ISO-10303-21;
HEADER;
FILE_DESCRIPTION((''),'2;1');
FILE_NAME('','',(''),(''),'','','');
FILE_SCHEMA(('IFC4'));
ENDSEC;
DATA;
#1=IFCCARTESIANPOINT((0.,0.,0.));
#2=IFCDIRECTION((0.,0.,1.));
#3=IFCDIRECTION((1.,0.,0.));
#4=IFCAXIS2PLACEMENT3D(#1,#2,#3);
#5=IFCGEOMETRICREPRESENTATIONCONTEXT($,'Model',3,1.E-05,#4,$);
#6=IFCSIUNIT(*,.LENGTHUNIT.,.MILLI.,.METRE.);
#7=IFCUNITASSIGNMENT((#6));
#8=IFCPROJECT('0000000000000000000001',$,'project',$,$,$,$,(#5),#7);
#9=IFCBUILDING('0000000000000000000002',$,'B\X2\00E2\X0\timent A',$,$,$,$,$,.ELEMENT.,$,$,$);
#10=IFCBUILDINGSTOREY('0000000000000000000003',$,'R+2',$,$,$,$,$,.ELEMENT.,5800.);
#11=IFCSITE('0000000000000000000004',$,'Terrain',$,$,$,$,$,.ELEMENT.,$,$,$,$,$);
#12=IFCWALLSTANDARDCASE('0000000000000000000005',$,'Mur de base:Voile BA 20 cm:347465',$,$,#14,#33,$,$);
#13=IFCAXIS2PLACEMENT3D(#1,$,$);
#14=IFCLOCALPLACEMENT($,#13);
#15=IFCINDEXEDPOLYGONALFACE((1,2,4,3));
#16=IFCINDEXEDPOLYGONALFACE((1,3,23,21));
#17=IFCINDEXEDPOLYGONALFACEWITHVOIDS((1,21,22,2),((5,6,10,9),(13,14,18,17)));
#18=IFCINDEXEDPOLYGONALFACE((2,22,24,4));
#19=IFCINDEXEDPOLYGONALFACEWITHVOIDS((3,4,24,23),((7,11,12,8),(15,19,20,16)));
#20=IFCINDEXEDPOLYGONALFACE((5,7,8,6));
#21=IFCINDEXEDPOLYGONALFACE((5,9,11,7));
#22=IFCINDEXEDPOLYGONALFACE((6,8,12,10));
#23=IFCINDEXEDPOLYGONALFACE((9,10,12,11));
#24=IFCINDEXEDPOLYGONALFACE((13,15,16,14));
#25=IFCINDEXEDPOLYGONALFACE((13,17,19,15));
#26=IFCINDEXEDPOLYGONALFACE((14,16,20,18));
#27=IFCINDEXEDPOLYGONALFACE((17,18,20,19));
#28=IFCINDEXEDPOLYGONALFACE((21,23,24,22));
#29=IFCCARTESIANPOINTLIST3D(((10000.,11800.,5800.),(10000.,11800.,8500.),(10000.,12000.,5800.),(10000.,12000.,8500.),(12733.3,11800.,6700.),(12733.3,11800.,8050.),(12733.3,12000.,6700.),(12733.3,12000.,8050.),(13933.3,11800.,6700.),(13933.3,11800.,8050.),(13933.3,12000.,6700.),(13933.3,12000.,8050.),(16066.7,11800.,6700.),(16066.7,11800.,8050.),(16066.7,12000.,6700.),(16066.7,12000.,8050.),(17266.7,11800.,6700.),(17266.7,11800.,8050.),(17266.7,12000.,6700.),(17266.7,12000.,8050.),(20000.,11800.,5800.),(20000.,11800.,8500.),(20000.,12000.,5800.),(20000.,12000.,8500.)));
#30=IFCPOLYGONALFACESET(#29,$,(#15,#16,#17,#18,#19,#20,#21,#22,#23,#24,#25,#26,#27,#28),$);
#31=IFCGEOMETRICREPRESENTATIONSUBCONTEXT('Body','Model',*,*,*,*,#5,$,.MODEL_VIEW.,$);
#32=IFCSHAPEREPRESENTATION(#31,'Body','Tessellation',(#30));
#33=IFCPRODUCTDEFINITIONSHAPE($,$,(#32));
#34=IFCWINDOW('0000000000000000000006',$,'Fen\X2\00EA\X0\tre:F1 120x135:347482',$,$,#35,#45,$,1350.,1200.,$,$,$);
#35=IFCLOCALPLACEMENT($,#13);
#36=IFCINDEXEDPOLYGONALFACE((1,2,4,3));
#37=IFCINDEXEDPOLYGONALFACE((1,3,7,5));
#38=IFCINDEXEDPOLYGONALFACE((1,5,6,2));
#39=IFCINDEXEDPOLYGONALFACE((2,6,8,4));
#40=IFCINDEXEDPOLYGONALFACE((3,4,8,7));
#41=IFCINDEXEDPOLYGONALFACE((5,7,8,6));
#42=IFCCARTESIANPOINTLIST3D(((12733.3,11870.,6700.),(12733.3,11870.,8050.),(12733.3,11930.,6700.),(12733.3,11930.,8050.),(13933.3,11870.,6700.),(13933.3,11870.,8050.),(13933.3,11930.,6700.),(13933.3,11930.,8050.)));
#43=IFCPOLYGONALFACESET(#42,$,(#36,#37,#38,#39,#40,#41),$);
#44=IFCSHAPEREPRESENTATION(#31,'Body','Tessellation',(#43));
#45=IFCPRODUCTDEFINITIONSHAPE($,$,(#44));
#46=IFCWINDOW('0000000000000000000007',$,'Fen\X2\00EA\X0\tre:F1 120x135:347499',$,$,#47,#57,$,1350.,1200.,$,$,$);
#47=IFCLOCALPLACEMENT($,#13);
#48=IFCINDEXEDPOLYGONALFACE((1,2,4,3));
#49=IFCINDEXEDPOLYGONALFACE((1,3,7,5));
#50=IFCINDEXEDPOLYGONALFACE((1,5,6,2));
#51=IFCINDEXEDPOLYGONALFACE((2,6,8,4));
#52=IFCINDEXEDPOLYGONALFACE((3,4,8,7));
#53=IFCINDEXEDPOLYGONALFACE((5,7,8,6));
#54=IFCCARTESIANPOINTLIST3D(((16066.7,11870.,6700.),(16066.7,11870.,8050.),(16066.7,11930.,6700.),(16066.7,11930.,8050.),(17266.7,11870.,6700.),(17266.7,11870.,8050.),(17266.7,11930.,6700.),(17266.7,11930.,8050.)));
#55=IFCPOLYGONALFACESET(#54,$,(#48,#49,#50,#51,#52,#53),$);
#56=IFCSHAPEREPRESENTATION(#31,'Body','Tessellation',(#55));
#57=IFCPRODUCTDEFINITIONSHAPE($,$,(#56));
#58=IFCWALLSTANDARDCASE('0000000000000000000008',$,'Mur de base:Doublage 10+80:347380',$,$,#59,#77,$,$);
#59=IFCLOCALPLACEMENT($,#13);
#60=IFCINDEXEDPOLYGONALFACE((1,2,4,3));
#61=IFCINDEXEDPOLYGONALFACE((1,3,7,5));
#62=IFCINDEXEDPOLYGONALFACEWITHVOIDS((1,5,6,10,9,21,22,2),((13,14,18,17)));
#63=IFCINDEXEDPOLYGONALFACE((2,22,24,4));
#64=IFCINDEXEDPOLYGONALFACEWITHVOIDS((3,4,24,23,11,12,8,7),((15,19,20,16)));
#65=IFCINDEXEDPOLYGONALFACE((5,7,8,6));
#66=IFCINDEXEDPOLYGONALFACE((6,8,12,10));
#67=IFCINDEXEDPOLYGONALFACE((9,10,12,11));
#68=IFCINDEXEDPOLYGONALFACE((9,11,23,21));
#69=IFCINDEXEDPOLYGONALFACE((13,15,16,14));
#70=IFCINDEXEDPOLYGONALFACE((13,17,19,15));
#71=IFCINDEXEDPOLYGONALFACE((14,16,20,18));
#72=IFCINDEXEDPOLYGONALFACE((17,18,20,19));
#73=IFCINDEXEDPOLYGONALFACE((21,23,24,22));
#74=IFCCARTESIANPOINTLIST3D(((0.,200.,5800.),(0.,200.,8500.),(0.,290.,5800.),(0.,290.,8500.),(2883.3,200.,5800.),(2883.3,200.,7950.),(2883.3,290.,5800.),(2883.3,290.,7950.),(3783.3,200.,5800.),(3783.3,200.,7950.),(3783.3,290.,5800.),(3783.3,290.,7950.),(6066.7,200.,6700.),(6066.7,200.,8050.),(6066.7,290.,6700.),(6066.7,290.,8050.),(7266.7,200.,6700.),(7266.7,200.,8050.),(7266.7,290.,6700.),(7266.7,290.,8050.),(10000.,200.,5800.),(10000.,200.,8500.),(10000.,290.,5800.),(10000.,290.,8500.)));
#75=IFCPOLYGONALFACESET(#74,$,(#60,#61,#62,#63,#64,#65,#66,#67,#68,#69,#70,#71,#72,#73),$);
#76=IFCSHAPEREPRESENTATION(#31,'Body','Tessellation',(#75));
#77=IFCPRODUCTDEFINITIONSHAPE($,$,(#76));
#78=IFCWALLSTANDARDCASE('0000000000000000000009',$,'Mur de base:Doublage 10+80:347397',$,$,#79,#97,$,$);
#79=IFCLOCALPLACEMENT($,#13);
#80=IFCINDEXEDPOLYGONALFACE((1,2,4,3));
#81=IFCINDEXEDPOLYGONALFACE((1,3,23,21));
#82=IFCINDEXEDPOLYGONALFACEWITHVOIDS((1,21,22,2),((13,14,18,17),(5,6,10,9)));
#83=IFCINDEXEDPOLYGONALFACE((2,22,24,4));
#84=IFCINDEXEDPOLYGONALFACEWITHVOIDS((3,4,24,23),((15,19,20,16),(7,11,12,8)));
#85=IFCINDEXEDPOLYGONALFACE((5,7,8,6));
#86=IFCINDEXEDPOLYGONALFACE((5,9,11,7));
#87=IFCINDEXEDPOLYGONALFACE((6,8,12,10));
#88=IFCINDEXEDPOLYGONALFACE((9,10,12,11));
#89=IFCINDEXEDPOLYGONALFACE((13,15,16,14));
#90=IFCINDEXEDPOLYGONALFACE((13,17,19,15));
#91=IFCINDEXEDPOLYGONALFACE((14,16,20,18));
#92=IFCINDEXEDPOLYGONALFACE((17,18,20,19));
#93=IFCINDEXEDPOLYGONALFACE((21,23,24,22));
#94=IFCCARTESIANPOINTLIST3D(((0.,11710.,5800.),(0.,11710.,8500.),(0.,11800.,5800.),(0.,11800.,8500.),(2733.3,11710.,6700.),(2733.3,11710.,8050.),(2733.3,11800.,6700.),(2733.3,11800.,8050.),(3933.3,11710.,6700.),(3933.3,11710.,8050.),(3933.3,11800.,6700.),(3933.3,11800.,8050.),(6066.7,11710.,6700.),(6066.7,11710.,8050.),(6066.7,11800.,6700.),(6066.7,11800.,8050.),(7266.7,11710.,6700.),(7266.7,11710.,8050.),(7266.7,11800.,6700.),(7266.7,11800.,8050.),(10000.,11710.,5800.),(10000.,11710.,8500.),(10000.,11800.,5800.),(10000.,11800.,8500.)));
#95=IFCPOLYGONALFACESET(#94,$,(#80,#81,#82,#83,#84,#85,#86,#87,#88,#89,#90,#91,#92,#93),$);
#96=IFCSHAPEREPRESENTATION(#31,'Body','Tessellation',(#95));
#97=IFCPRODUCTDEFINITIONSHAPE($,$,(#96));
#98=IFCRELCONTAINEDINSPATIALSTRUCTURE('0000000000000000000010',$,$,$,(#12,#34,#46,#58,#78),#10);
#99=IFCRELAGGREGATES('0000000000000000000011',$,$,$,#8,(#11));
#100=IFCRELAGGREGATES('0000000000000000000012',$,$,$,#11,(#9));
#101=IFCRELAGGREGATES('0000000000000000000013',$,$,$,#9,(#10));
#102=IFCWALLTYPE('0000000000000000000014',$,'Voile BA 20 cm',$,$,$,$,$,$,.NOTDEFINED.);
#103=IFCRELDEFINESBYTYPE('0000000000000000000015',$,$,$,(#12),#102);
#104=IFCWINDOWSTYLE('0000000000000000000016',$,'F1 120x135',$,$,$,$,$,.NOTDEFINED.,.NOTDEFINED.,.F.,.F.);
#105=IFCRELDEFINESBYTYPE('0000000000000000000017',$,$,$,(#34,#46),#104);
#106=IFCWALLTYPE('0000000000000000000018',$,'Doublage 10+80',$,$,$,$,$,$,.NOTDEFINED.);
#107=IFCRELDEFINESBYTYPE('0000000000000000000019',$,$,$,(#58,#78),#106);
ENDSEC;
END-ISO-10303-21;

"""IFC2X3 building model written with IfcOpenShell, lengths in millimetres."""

from ifc_helpers import new_model, si_unit, frame, frame_2d, origin_with_axes, place, context, subcontext, project, spatial, rectangle, extrude, type_object, element, fill, save


model = new_model("IFC2X3")

# Units and contexts
model_context = context("Model", 3, precision=1e-05, world=origin_with_axes())
body_context = subcontext(model_context, "Body", "Model", "MODEL_VIEW")
ifc_project = project(units=[si_unit("LENGTHUNIT", "METRE", prefix="MILLI")], contexts=[model_context])

# Site, building, storey
site = spatial("IfcSite", under=ifc_project, Name="Terrain", CompositionType="ELEMENT")
building = spatial("IfcBuilding", under=site, Name="Bâtiment A", CompositionType="ELEMENT")
storey = spatial("IfcBuildingStorey", under=building, Name="R+2", CompositionType="ELEMENT", Elevation=5800.0)

# Shared definitions
wall_type_1 = type_object("IfcWallType", Name="Voile BA 20 cm", PredefinedType="NOTDEFINED")
window_style = type_object("IfcWindowStyle", Name="F1 120x135", ConstructionType="NOTDEFINED", OperationType="NOTDEFINED", ParameterTakesPrecedence=False, Sizeable=False)

# Wall, openings, windows
wall_1_placement = place(None, origin_with_axes())
wall_1 = element("IfcWallStandardCase", 1, at=wall_1_placement, inside=storey, type_object=wall_type_1, Name="Mur de base:Voile BA 20 cm:347465", context=body_context, shape_type="SweptSolid", body=[
    extrude(rectangle(XDim=10000.0, YDim=200.0, at=frame_2d((15000.0, 11900.0))), frame((0.0, 0.0, 5800.0), z_axis=(0.0, 0.0, 1.0), x_axis=(1.0, 0.0, 0.0)), (0.0, 0.0, 1.0), 2700.0),
])
opening_1_placement = place(None, origin_with_axes())
opening_1 = element("IfcOpeningElement", 2, at=opening_1_placement, cuts=wall_1, context=body_context, shape_type="SweptSolid", body=[
    extrude(rectangle(XDim=1200.0, YDim=320.0, at=frame_2d((13333.3, 11900.0))), frame((0.0, 0.0, 6700.0), z_axis=(0.0, 0.0, 1.0), x_axis=(1.0, 0.0, 0.0)), (0.0, 0.0, 1.0), 1350.0),
])
opening_2_placement = place(None, origin_with_axes())
opening_2 = element("IfcOpeningElement", 3, at=opening_2_placement, cuts=wall_1, context=body_context, shape_type="SweptSolid", body=[
    extrude(rectangle(XDim=1200.0, YDim=320.0, at=frame_2d((16666.7, 11900.0))), frame((0.0, 0.0, 6700.0), z_axis=(0.0, 0.0, 1.0), x_axis=(1.0, 0.0, 0.0)), (0.0, 0.0, 1.0), 1350.0),
])
window_1_placement = place(None, origin_with_axes())
window_1 = element("IfcWindow", 4, at=window_1_placement, inside=storey, type_object=window_style, Name="Fenêtre:F1 120x135:347482", OverallHeight=1350.0, OverallWidth=1200.0, context=body_context, shape_type="SweptSolid", body=[
    extrude(rectangle(XDim=1200.0, YDim=60.0, at=frame_2d((13333.3, 11900.0))), frame((0.0, 0.0, 6700.0), z_axis=(0.0, 0.0, 1.0), x_axis=(1.0, 0.0, 0.0)), (0.0, 0.0, 1.0), 1350.0),
])
fill(opening_1, window_1)
window_2_placement = place(None, origin_with_axes())
window_2 = element("IfcWindow", 5, at=window_2_placement, inside=storey, type_object=window_style, Name="Fenêtre:F1 120x135:347499", OverallHeight=1350.0, OverallWidth=1200.0, context=body_context, shape_type="SweptSolid", body=[
    extrude(rectangle(XDim=1200.0, YDim=60.0, at=frame_2d((16666.7, 11900.0))), frame((0.0, 0.0, 6700.0), z_axis=(0.0, 0.0, 1.0), x_axis=(1.0, 0.0, 0.0)), (0.0, 0.0, 1.0), 1350.0),
])
fill(opening_2, window_2)

# Walls, openings
wall_type_2 = type_object("IfcWallType", Name="Doublage 10+80", PredefinedType="NOTDEFINED")
wall_2_placement = place(None, origin_with_axes())
wall_2 = element("IfcWallStandardCase", 6, at=wall_2_placement, inside=storey, type_object=wall_type_2, Name="Mur de base:Doublage 10+80:347380", context=body_context, shape_type="SweptSolid", body=[
    extrude(rectangle(XDim=10000.0, YDim=90.0, at=frame_2d((5000.0, 245.0))), frame((0.0, 0.0, 5800.0), z_axis=(0.0, 0.0, 1.0), x_axis=(1.0, 0.0, 0.0)), (0.0, 0.0, 1.0), 2700.0),
])
opening_3_placement = place(None, origin_with_axes())
element("IfcOpeningElement", 7, at=opening_3_placement, cuts=wall_2, context=body_context, shape_type="SweptSolid", body=[
    extrude(rectangle(XDim=900.0, YDim=210.0, at=frame_2d((3333.3, 245.0))), frame((0.0, 0.0, 5800.0), z_axis=(0.0, 0.0, 1.0), x_axis=(1.0, 0.0, 0.0)), (0.0, 0.0, 1.0), 2150.0),
])
opening_4_placement = place(None, origin_with_axes())
element("IfcOpeningElement", 8, at=opening_4_placement, cuts=wall_2, context=body_context, shape_type="SweptSolid", body=[
    extrude(rectangle(XDim=1200.0, YDim=210.0, at=frame_2d((6666.7, 245.0))), frame((0.0, 0.0, 6700.0), z_axis=(0.0, 0.0, 1.0), x_axis=(1.0, 0.0, 0.0)), (0.0, 0.0, 1.0), 1350.0),
])
wall_3_placement = place(None, origin_with_axes())
wall_3 = element("IfcWallStandardCase", 9, at=wall_3_placement, inside=storey, type_object=wall_type_2, Name="Mur de base:Doublage 10+80:347397", context=body_context, shape_type="SweptSolid", body=[
    extrude(rectangle(XDim=10000.0, YDim=90.0, at=frame_2d((5000.0, 11755.0))), frame((0.0, 0.0, 5800.0), z_axis=(0.0, 0.0, 1.0), x_axis=(1.0, 0.0, 0.0)), (0.0, 0.0, 1.0), 2700.0),
])
opening_5_placement = place(None, origin_with_axes())
element("IfcOpeningElement", 10, at=opening_5_placement, cuts=wall_3, context=body_context, shape_type="SweptSolid", body=[
    extrude(rectangle(XDim=1200.0, YDim=210.0, at=frame_2d((3333.3, 11755.0))), frame((0.0, 0.0, 6700.0), z_axis=(0.0, 0.0, 1.0), x_axis=(1.0, 0.0, 0.0)), (0.0, 0.0, 1.0), 1350.0),
])
opening_6_placement = place(None, origin_with_axes())
element("IfcOpeningElement", 11, at=opening_6_placement, cuts=wall_3, context=body_context, shape_type="SweptSolid", body=[
    extrude(rectangle(XDim=1200.0, YDim=210.0, at=frame_2d((6666.7, 11755.0))), frame((0.0, 0.0, 6700.0), z_axis=(0.0, 0.0, 1.0), x_axis=(1.0, 0.0, 0.0)), (0.0, 0.0, 1.0), 1350.0),
])

save(model, "model.ifc")
